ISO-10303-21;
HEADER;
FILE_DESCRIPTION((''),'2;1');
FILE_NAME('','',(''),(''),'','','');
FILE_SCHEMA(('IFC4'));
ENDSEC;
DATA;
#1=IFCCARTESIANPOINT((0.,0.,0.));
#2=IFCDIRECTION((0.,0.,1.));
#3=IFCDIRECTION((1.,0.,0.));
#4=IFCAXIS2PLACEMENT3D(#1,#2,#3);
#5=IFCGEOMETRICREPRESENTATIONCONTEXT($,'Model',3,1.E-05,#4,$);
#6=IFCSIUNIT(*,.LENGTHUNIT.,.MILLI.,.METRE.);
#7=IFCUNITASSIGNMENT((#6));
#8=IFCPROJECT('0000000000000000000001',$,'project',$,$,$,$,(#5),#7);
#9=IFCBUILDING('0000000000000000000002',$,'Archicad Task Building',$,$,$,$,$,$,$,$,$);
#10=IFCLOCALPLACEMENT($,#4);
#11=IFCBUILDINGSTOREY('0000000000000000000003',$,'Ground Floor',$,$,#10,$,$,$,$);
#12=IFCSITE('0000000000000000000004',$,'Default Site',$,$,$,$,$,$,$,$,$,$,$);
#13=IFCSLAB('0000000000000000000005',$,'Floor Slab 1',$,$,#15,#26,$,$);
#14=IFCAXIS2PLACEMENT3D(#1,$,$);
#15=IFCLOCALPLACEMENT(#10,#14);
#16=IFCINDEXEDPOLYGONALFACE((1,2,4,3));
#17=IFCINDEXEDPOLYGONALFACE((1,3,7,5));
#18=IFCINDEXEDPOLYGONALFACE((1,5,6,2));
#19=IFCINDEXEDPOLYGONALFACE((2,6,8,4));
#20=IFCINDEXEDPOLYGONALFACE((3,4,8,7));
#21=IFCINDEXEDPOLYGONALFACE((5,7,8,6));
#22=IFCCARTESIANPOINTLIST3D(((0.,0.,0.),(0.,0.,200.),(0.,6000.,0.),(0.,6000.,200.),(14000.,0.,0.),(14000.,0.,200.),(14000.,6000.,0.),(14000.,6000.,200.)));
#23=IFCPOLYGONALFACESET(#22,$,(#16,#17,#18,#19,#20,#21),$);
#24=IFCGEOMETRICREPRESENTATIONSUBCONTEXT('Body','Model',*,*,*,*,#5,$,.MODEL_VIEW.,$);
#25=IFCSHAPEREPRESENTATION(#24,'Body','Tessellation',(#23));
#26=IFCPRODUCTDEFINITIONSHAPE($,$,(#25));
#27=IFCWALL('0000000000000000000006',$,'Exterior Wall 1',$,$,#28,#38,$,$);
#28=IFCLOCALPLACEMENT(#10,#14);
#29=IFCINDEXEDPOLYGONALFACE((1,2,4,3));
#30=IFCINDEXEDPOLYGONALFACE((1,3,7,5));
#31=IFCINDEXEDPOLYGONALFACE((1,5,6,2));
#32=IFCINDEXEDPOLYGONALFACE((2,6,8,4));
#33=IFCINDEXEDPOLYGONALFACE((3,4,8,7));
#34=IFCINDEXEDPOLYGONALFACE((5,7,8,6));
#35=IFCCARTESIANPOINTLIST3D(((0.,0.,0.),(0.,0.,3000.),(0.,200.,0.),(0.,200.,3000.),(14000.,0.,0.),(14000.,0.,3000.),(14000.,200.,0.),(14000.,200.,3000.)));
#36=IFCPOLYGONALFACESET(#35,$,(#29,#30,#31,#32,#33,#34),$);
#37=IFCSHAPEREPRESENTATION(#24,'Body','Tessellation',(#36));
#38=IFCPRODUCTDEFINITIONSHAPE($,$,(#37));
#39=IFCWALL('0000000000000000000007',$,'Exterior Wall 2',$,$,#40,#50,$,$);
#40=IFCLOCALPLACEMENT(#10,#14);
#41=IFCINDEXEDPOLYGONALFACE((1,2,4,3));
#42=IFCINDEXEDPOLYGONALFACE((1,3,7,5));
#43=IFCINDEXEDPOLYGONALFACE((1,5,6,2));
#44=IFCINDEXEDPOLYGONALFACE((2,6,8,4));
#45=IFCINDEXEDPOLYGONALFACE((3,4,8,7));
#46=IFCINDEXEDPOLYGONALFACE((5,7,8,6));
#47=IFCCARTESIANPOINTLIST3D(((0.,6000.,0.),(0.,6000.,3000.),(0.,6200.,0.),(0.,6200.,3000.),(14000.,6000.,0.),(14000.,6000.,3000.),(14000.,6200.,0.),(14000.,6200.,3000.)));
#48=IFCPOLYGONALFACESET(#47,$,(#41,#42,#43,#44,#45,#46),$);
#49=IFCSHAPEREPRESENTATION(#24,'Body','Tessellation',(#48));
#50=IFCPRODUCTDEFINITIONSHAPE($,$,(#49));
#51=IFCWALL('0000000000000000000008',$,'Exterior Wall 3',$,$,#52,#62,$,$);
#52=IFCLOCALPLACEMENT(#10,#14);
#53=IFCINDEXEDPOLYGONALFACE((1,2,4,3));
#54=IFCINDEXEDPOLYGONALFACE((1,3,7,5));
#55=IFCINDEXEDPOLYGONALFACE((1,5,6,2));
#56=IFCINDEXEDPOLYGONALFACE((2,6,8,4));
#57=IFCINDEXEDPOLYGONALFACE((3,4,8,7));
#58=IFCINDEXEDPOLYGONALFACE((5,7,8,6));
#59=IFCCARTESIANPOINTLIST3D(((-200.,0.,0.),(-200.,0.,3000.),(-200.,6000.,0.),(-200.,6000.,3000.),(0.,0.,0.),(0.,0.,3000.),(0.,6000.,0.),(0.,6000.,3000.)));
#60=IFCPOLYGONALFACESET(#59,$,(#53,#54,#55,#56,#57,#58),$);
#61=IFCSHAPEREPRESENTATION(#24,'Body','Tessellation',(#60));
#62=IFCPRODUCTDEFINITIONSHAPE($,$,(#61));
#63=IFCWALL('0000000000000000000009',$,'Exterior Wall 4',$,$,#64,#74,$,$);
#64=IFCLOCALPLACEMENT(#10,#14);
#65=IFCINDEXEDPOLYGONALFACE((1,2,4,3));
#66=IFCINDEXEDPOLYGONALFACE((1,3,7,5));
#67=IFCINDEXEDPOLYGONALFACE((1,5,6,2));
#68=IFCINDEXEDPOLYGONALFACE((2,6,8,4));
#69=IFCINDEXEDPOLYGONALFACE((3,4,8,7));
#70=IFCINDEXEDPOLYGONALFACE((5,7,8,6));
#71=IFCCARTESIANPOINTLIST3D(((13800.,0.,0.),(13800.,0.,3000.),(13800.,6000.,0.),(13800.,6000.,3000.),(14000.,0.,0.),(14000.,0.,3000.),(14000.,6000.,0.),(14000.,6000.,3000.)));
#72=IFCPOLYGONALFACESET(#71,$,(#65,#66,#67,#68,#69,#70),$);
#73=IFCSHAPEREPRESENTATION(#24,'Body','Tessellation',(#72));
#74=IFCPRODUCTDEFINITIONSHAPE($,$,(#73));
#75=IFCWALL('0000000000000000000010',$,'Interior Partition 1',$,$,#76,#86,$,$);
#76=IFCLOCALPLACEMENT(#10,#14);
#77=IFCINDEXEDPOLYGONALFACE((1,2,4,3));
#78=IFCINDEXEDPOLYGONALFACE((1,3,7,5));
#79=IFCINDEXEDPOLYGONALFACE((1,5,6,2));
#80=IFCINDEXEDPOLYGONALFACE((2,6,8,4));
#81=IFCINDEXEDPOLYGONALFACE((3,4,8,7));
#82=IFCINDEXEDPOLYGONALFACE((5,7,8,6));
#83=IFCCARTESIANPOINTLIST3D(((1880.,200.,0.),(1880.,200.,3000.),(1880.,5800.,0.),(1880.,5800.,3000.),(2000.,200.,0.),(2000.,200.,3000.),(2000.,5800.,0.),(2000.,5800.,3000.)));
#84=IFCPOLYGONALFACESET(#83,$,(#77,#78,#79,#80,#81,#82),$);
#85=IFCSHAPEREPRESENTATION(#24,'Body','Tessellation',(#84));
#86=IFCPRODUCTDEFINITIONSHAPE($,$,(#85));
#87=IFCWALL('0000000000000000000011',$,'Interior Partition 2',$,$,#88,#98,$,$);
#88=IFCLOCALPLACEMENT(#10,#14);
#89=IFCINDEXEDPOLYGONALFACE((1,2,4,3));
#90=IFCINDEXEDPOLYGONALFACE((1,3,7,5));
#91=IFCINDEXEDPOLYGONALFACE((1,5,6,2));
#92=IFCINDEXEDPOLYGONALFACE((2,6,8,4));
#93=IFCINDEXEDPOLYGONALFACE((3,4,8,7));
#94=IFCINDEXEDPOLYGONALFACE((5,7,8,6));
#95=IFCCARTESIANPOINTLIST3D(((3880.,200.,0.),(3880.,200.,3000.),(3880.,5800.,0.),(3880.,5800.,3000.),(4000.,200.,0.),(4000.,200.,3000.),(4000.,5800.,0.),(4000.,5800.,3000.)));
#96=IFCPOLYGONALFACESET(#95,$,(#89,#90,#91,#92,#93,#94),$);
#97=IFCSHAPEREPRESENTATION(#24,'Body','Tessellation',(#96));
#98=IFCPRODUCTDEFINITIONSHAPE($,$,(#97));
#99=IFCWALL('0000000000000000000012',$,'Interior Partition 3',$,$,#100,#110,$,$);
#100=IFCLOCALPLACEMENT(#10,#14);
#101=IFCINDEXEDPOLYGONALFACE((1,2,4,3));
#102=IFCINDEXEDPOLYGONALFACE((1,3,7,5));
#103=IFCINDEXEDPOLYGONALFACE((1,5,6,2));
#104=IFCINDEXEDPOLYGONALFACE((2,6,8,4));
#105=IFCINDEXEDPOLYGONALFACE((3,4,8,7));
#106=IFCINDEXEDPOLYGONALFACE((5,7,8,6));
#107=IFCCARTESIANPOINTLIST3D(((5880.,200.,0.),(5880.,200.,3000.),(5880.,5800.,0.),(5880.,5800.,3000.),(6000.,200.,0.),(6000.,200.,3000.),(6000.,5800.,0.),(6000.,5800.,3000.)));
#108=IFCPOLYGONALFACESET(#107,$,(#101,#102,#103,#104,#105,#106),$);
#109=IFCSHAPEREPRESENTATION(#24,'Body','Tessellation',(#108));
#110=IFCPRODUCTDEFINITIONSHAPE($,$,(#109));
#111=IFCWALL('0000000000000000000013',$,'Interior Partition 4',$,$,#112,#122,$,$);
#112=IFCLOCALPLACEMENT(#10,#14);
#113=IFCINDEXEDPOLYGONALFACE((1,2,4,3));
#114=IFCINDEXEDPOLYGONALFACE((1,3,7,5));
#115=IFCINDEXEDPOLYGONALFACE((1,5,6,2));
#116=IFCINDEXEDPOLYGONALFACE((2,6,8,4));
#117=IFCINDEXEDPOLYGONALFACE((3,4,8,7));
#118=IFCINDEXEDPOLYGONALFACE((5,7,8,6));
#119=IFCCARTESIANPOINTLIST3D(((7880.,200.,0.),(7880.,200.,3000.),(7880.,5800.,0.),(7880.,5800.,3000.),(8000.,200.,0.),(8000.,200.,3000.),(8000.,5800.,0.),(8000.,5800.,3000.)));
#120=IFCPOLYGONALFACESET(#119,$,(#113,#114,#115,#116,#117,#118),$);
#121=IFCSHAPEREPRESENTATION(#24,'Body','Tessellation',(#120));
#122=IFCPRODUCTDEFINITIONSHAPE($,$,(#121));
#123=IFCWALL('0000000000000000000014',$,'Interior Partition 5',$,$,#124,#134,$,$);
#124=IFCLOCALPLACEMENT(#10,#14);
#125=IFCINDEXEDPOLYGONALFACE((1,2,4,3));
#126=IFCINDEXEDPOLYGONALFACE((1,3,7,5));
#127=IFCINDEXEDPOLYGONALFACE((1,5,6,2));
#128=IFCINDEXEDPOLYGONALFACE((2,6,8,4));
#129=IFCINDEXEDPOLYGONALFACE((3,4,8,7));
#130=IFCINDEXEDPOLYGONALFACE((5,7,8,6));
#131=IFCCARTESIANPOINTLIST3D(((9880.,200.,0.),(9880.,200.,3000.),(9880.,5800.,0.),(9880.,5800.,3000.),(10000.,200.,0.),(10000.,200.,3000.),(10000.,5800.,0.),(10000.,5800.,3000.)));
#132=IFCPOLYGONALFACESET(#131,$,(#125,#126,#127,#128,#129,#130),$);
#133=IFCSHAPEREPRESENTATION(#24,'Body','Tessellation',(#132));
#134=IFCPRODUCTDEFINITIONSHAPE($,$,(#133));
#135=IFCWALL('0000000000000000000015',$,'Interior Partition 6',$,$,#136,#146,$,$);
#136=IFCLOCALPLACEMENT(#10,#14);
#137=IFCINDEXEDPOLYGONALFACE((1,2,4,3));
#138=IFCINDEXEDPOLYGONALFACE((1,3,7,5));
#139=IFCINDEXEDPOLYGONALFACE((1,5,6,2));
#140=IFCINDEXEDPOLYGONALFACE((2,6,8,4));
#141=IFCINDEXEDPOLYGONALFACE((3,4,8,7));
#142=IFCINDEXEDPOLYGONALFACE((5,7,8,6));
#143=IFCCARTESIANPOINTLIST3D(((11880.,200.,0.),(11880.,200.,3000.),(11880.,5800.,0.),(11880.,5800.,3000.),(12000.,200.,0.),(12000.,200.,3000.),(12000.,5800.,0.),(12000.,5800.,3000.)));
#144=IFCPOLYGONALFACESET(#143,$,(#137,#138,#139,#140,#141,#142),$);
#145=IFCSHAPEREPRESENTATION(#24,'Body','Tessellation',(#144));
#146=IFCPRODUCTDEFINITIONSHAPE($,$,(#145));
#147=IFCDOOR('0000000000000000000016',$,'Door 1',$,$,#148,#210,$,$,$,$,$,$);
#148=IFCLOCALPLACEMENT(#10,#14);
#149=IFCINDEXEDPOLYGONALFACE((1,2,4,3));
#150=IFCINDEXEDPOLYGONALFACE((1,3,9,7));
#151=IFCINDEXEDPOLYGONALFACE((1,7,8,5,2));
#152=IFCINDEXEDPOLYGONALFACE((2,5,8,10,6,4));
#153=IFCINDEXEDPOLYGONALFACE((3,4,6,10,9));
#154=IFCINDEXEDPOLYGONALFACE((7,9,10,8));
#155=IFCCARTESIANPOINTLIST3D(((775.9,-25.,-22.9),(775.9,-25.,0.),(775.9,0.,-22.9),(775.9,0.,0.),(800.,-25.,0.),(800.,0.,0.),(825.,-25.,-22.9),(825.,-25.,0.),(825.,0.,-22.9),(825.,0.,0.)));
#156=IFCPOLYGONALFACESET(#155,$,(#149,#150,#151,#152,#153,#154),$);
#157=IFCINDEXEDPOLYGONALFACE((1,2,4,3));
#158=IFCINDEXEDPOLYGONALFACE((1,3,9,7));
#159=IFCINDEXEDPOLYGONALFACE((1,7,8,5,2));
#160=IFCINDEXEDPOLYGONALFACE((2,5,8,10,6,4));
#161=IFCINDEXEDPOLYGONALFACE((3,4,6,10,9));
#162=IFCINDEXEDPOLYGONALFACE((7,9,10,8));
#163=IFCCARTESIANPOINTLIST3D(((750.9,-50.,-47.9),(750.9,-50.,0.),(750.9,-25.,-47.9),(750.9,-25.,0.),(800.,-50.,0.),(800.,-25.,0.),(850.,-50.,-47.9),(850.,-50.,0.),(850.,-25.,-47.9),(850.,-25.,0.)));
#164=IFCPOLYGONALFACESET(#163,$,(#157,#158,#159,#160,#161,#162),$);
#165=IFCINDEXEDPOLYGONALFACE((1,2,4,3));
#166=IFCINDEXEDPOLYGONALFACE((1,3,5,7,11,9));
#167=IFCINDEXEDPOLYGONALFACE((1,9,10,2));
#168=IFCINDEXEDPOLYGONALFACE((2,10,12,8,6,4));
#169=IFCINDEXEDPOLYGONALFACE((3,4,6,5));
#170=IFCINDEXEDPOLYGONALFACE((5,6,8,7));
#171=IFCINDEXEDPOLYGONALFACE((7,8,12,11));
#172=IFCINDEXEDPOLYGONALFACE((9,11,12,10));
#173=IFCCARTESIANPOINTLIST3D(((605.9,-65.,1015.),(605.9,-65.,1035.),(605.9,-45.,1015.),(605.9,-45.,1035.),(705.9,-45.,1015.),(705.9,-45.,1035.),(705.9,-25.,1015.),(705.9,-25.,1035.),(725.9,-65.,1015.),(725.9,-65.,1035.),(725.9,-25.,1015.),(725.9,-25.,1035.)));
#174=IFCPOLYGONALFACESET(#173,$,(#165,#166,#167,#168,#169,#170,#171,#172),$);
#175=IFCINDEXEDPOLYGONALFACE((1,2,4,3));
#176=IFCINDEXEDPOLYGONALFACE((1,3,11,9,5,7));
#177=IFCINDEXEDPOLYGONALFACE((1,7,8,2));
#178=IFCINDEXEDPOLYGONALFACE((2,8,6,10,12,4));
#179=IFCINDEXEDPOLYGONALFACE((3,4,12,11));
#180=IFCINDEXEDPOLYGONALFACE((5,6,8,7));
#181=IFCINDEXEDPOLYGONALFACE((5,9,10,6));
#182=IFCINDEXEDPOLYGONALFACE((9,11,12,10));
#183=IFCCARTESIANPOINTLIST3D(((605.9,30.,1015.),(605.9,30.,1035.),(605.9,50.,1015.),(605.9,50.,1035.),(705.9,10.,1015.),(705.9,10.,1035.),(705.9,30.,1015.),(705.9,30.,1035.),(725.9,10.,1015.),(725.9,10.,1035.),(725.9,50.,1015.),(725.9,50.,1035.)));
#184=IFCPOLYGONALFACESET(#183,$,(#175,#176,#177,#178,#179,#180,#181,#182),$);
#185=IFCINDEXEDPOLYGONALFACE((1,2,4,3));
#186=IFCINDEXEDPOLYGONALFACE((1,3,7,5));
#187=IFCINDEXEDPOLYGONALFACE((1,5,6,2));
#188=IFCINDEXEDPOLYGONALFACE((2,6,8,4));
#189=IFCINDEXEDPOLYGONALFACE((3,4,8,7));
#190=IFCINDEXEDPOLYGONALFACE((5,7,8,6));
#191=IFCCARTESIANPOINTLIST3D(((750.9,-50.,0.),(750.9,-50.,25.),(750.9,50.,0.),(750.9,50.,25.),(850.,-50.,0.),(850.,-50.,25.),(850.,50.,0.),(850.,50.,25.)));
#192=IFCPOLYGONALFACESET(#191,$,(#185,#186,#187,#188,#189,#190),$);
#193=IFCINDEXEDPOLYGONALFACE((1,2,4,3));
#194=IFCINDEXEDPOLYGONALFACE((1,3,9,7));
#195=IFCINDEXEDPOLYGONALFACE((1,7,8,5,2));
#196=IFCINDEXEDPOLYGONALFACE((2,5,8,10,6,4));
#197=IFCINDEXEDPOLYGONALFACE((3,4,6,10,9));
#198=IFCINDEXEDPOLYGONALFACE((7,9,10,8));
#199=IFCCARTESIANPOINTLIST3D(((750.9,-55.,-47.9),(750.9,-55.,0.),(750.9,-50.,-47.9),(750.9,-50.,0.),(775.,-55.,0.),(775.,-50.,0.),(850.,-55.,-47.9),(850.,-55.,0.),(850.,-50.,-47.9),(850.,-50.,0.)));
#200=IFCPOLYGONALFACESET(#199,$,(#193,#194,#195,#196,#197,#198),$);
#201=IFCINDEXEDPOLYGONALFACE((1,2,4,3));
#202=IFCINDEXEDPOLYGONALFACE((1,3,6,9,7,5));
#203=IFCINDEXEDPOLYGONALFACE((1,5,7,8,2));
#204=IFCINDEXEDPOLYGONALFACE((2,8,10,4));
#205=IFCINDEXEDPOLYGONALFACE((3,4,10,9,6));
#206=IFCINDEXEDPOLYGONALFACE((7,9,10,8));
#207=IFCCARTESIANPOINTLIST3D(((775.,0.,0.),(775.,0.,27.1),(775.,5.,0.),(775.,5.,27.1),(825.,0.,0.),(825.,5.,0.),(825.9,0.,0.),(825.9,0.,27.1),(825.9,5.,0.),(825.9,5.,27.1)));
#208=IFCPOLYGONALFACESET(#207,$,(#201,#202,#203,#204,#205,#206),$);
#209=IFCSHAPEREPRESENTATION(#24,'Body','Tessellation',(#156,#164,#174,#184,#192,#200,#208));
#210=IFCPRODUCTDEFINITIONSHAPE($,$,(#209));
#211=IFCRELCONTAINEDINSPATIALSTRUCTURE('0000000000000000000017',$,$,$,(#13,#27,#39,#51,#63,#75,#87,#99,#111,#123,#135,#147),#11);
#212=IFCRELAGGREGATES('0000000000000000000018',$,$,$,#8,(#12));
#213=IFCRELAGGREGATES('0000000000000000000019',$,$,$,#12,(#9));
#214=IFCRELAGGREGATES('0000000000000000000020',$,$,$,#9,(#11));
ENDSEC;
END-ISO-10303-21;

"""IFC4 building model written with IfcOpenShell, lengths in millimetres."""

from ifc_helpers import new_model, si_unit, frame, origin_with_axes, place, context, subcontext, project, spatial, line, indexed_curve, outline, extrude, element, save


model = new_model("IFC4")

# Units and contexts
model_context = context("Model", 3, precision=1e-05, world=origin_with_axes())
body_context = subcontext(model_context, "Body", "Model", "MODEL_VIEW")
ifc_project = project(units=[si_unit("LENGTHUNIT", "METRE", prefix="MILLI")], contexts=[model_context])

# Site, building, storey
site = spatial("IfcSite", under=ifc_project, Name="Default Site")
building = spatial("IfcBuilding", under=site, Name="Archicad Task Building")
storey_placement = place(None, origin_with_axes())
storey = spatial("IfcBuildingStorey", under=building, at=storey_placement, Name="Ground Floor")

# Slab
slab_placement = place(storey_placement, origin_with_axes())
element("IfcSlab", 1, at=slab_placement, inside=storey, Name="Floor Slab 1", context=body_context, shape_type="SweptSolid", body=[
    extrude(outline(indexed_curve([(0.0, 0.0), (14000.0, 0.0), (14000.0, 6000.0), (0.0, 6000.0), (0.0, 0.0)])), None, (0.0, 0.0, 1.0), 200.0),
])

# Walls
for number, where, z_axis, x_axis, name in (
    (2, (0.0, 0.0, 0.0), (0.0, 0.0, 1.0), (1.0, 0.0, 0.0), "Exterior Wall 1"),
    (3, (0.0, 6000.0, 0.0), (0.0, 0.0, 1.0), (1.0, 0.0, 0.0), "Exterior Wall 2"),
):
    element("IfcWall", number, at=place(storey_placement, frame(where, z_axis=z_axis, x_axis=x_axis)), inside=storey, Name=name, context=body_context, shape_type="SweptSolid", body=[
        extrude(outline(indexed_curve([(0.0, 0.0), (0.0, 200.0), (14000.0, 200.0), (14000.0, 0.0), (0.0, 0.0)], self_intersect=False)), origin_with_axes(), (0.0, 0.0, 1.0), 3000.0),
    ])
for number, where, z_axis, x_axis, name in (
    (4, (0.0, 0.0, 0.0), (0.0, 0.0, 1.0), (0.0, 1.0, 0.0), "Exterior Wall 3"),
    (5, (14000.0, 0.0, 0.0), (0.0, 0.0, 1.0), (0.0, 1.0, 0.0), "Exterior Wall 4"),
):
    element("IfcWall", number, at=place(storey_placement, frame(where, z_axis=z_axis, x_axis=x_axis)), inside=storey, Name=name, context=body_context, shape_type="SweptSolid", body=[
        extrude(outline(indexed_curve([(0.0, 0.0), (0.0, 200.0), (6000.0, 200.0), (6000.0, 0.0), (0.0, 0.0)], self_intersect=False)), origin_with_axes(), (0.0, 0.0, 1.0), 3000.0),
    ])
for number, where, z_axis, x_axis, name in (
    (6, (2000.0, 200.0, 0.0), (0.0, 0.0, 1.0), (0.0, 1.0, 0.0), "Interior Partition 1"),
    (7, (4000.0, 200.0, 0.0), (0.0, 0.0, 1.0), (0.0, 1.0, 0.0), "Interior Partition 2"),
    (8, (6000.0, 200.0, 0.0), (0.0, 0.0, 1.0), (0.0, 1.0, 0.0), "Interior Partition 3"),
    (9, (8000.0, 200.0, 0.0), (0.0, 0.0, 1.0), (0.0, 1.0, 0.0), "Interior Partition 4"),
    (10, (10000.0, 200.0, 0.0), (0.0, 0.0, 1.0), (0.0, 1.0, 0.0), "Interior Partition 5"),
    (11, (12000.0, 200.0, 0.0), (0.0, 0.0, 1.0), (0.0, 1.0, 0.0), "Interior Partition 6"),
):
    element("IfcWall", number, at=place(storey_placement, frame(where, z_axis=z_axis, x_axis=x_axis)), inside=storey, Name=name, context=body_context, shape_type="SweptSolid", body=[
        extrude(outline(indexed_curve([(0.0, 0.0), (0.0, 120.0), (5600.0, 120.0), (5600.0, 0.0), (0.0, 0.0)], self_intersect=False)), origin_with_axes(), (0.0, 0.0, 1.0), 3000.0),
    ])

# Door
door_1_placement = place(storey_placement, frame((800.0, -50.0, 0.0), z_axis=(0.0, 0.0, 1.0), x_axis=(1.0, 0.0, 0.0)))
element("IfcDoor", 12, at=door_1_placement, inside=storey, Name="Door 1", context=body_context, shape_type="SweptSolid", body=[
    extrude(outline(indexed_curve([(0.0, 0.0), (0.0, 2.1), (0.9, 2.1), (0.9, 0.0), (-24.1, 0.0), (-24.1, -22.9), (25.0, -22.9), (25.0, 0.0)], segments=[line(1, 2, 3, 4, 5, 6, 7, 8, 1)])), frame((0.0, 25.0, 0.0), z_axis=(0.0, -1.0, 0.0), x_axis=(1.0, 0.0, 0.0)), (0.0, 0.0, -1.0), 25.0),
    extrude(outline(indexed_curve([(0.0, 0.0), (0.0, 2.1), (0.9, 2.1), (0.9, 0.0), (-49.1, 0.0), (-49.1, -47.9), (50.0, -47.9), (50.0, 0.0)], segments=[line(1, 2, 3, 4, 5, 6, 7, 8, 1)])), frame((0.0, 0.0, 0.0), z_axis=(0.0, -1.0, 0.0), x_axis=(1.0, 0.0, 0.0)), (0.0, 0.0, -1.0), 25.0),
    extrude(outline(indexed_curve([(0.0, 0.0), (-49.1, 0.0), (-49.1, 35.0), (0.0, 35.0)], segments=[line(1, 2, 3, 4, 1)])), frame((25.0, 25.0, 25.0), z_axis=(0.0, 0.0, 1.0), x_axis=(1.0, 0.0, 0.0)), (0.0, 0.0, 1.0), -47.9),
    extrude(outline(indexed_curve([(0.0, 0.0), (0.0, -40.0), (-120.0, -40.0), (-120.0, -20.0), (-20.0, -20.0), (-20.0, 0.0)], segments=[line(1, 2, 3, 4, 5, 6, 1)])), frame((-74.1, 25.0, 1015.0), z_axis=(0.0, 0.0, 1.0), x_axis=(1.0, 0.0, 0.0)), (0.0, 0.0, 1.0), 20.0),
    extrude(outline(indexed_curve([(0.0, 0.0), (0.0, 40.0), (-120.0, 40.0), (-120.0, 20.0), (-20.0, 20.0), (-20.0, 0.0)], segments=[line(1, 2, 3, 4, 5, 6, 1)])), frame((-74.1, 60.0, 1015.0), z_axis=(0.0, 0.0, 1.0), x_axis=(1.0, 0.0, 0.0)), (0.0, 0.0, 1.0), 20.0),
    extrude(outline(indexed_curve([(0.0, 0.0), (-99.1, 0.0), (-99.1, 100.0), (0.0, 100.0)], segments=[line(1, 2, 3, 4, 1)])), frame((50.0, 0.0, 0.0), z_axis=(0.0, 0.0, 1.0), x_axis=(1.0, 0.0, 0.0)), (0.0, 0.0, 1.0), 25.0),
    extrude(outline(indexed_curve([(0.0, 0.0), (0.0, 27.1), (50.9, 27.1), (50.9, 0.0), (-24.1, 0.0), (-24.1, -47.9), (75.0, -47.9), (75.0, 0.0)], segments=[line(1, 2, 3, 4, 5, 6, 7, 8, 1)])), frame((-25.0, -5.0, 0.0), z_axis=(0.0, -1.0, 0.0), x_axis=(1.0, 0.0, 0.0)), (0.0, 0.0, -1.0), 5.0),
    extrude(outline(indexed_curve([(0.0, 0.0), (0.0, 27.1), (50.9, 27.1), (50.9, 0.0), (0.9, 0.0), (0.9, -22.9), (50.0, -22.9), (50.0, 0.0)], segments=[line(1, 2, 3, 4, 5, 6, 7, 8, 1)])), frame((-25.0, 50.0, 0.0), z_axis=(0.0, -1.0, 0.0), x_axis=(1.0, 0.0, 0.0)), (0.0, 0.0, -1.0), 5.0),
])

save(model, "model.ifc")
